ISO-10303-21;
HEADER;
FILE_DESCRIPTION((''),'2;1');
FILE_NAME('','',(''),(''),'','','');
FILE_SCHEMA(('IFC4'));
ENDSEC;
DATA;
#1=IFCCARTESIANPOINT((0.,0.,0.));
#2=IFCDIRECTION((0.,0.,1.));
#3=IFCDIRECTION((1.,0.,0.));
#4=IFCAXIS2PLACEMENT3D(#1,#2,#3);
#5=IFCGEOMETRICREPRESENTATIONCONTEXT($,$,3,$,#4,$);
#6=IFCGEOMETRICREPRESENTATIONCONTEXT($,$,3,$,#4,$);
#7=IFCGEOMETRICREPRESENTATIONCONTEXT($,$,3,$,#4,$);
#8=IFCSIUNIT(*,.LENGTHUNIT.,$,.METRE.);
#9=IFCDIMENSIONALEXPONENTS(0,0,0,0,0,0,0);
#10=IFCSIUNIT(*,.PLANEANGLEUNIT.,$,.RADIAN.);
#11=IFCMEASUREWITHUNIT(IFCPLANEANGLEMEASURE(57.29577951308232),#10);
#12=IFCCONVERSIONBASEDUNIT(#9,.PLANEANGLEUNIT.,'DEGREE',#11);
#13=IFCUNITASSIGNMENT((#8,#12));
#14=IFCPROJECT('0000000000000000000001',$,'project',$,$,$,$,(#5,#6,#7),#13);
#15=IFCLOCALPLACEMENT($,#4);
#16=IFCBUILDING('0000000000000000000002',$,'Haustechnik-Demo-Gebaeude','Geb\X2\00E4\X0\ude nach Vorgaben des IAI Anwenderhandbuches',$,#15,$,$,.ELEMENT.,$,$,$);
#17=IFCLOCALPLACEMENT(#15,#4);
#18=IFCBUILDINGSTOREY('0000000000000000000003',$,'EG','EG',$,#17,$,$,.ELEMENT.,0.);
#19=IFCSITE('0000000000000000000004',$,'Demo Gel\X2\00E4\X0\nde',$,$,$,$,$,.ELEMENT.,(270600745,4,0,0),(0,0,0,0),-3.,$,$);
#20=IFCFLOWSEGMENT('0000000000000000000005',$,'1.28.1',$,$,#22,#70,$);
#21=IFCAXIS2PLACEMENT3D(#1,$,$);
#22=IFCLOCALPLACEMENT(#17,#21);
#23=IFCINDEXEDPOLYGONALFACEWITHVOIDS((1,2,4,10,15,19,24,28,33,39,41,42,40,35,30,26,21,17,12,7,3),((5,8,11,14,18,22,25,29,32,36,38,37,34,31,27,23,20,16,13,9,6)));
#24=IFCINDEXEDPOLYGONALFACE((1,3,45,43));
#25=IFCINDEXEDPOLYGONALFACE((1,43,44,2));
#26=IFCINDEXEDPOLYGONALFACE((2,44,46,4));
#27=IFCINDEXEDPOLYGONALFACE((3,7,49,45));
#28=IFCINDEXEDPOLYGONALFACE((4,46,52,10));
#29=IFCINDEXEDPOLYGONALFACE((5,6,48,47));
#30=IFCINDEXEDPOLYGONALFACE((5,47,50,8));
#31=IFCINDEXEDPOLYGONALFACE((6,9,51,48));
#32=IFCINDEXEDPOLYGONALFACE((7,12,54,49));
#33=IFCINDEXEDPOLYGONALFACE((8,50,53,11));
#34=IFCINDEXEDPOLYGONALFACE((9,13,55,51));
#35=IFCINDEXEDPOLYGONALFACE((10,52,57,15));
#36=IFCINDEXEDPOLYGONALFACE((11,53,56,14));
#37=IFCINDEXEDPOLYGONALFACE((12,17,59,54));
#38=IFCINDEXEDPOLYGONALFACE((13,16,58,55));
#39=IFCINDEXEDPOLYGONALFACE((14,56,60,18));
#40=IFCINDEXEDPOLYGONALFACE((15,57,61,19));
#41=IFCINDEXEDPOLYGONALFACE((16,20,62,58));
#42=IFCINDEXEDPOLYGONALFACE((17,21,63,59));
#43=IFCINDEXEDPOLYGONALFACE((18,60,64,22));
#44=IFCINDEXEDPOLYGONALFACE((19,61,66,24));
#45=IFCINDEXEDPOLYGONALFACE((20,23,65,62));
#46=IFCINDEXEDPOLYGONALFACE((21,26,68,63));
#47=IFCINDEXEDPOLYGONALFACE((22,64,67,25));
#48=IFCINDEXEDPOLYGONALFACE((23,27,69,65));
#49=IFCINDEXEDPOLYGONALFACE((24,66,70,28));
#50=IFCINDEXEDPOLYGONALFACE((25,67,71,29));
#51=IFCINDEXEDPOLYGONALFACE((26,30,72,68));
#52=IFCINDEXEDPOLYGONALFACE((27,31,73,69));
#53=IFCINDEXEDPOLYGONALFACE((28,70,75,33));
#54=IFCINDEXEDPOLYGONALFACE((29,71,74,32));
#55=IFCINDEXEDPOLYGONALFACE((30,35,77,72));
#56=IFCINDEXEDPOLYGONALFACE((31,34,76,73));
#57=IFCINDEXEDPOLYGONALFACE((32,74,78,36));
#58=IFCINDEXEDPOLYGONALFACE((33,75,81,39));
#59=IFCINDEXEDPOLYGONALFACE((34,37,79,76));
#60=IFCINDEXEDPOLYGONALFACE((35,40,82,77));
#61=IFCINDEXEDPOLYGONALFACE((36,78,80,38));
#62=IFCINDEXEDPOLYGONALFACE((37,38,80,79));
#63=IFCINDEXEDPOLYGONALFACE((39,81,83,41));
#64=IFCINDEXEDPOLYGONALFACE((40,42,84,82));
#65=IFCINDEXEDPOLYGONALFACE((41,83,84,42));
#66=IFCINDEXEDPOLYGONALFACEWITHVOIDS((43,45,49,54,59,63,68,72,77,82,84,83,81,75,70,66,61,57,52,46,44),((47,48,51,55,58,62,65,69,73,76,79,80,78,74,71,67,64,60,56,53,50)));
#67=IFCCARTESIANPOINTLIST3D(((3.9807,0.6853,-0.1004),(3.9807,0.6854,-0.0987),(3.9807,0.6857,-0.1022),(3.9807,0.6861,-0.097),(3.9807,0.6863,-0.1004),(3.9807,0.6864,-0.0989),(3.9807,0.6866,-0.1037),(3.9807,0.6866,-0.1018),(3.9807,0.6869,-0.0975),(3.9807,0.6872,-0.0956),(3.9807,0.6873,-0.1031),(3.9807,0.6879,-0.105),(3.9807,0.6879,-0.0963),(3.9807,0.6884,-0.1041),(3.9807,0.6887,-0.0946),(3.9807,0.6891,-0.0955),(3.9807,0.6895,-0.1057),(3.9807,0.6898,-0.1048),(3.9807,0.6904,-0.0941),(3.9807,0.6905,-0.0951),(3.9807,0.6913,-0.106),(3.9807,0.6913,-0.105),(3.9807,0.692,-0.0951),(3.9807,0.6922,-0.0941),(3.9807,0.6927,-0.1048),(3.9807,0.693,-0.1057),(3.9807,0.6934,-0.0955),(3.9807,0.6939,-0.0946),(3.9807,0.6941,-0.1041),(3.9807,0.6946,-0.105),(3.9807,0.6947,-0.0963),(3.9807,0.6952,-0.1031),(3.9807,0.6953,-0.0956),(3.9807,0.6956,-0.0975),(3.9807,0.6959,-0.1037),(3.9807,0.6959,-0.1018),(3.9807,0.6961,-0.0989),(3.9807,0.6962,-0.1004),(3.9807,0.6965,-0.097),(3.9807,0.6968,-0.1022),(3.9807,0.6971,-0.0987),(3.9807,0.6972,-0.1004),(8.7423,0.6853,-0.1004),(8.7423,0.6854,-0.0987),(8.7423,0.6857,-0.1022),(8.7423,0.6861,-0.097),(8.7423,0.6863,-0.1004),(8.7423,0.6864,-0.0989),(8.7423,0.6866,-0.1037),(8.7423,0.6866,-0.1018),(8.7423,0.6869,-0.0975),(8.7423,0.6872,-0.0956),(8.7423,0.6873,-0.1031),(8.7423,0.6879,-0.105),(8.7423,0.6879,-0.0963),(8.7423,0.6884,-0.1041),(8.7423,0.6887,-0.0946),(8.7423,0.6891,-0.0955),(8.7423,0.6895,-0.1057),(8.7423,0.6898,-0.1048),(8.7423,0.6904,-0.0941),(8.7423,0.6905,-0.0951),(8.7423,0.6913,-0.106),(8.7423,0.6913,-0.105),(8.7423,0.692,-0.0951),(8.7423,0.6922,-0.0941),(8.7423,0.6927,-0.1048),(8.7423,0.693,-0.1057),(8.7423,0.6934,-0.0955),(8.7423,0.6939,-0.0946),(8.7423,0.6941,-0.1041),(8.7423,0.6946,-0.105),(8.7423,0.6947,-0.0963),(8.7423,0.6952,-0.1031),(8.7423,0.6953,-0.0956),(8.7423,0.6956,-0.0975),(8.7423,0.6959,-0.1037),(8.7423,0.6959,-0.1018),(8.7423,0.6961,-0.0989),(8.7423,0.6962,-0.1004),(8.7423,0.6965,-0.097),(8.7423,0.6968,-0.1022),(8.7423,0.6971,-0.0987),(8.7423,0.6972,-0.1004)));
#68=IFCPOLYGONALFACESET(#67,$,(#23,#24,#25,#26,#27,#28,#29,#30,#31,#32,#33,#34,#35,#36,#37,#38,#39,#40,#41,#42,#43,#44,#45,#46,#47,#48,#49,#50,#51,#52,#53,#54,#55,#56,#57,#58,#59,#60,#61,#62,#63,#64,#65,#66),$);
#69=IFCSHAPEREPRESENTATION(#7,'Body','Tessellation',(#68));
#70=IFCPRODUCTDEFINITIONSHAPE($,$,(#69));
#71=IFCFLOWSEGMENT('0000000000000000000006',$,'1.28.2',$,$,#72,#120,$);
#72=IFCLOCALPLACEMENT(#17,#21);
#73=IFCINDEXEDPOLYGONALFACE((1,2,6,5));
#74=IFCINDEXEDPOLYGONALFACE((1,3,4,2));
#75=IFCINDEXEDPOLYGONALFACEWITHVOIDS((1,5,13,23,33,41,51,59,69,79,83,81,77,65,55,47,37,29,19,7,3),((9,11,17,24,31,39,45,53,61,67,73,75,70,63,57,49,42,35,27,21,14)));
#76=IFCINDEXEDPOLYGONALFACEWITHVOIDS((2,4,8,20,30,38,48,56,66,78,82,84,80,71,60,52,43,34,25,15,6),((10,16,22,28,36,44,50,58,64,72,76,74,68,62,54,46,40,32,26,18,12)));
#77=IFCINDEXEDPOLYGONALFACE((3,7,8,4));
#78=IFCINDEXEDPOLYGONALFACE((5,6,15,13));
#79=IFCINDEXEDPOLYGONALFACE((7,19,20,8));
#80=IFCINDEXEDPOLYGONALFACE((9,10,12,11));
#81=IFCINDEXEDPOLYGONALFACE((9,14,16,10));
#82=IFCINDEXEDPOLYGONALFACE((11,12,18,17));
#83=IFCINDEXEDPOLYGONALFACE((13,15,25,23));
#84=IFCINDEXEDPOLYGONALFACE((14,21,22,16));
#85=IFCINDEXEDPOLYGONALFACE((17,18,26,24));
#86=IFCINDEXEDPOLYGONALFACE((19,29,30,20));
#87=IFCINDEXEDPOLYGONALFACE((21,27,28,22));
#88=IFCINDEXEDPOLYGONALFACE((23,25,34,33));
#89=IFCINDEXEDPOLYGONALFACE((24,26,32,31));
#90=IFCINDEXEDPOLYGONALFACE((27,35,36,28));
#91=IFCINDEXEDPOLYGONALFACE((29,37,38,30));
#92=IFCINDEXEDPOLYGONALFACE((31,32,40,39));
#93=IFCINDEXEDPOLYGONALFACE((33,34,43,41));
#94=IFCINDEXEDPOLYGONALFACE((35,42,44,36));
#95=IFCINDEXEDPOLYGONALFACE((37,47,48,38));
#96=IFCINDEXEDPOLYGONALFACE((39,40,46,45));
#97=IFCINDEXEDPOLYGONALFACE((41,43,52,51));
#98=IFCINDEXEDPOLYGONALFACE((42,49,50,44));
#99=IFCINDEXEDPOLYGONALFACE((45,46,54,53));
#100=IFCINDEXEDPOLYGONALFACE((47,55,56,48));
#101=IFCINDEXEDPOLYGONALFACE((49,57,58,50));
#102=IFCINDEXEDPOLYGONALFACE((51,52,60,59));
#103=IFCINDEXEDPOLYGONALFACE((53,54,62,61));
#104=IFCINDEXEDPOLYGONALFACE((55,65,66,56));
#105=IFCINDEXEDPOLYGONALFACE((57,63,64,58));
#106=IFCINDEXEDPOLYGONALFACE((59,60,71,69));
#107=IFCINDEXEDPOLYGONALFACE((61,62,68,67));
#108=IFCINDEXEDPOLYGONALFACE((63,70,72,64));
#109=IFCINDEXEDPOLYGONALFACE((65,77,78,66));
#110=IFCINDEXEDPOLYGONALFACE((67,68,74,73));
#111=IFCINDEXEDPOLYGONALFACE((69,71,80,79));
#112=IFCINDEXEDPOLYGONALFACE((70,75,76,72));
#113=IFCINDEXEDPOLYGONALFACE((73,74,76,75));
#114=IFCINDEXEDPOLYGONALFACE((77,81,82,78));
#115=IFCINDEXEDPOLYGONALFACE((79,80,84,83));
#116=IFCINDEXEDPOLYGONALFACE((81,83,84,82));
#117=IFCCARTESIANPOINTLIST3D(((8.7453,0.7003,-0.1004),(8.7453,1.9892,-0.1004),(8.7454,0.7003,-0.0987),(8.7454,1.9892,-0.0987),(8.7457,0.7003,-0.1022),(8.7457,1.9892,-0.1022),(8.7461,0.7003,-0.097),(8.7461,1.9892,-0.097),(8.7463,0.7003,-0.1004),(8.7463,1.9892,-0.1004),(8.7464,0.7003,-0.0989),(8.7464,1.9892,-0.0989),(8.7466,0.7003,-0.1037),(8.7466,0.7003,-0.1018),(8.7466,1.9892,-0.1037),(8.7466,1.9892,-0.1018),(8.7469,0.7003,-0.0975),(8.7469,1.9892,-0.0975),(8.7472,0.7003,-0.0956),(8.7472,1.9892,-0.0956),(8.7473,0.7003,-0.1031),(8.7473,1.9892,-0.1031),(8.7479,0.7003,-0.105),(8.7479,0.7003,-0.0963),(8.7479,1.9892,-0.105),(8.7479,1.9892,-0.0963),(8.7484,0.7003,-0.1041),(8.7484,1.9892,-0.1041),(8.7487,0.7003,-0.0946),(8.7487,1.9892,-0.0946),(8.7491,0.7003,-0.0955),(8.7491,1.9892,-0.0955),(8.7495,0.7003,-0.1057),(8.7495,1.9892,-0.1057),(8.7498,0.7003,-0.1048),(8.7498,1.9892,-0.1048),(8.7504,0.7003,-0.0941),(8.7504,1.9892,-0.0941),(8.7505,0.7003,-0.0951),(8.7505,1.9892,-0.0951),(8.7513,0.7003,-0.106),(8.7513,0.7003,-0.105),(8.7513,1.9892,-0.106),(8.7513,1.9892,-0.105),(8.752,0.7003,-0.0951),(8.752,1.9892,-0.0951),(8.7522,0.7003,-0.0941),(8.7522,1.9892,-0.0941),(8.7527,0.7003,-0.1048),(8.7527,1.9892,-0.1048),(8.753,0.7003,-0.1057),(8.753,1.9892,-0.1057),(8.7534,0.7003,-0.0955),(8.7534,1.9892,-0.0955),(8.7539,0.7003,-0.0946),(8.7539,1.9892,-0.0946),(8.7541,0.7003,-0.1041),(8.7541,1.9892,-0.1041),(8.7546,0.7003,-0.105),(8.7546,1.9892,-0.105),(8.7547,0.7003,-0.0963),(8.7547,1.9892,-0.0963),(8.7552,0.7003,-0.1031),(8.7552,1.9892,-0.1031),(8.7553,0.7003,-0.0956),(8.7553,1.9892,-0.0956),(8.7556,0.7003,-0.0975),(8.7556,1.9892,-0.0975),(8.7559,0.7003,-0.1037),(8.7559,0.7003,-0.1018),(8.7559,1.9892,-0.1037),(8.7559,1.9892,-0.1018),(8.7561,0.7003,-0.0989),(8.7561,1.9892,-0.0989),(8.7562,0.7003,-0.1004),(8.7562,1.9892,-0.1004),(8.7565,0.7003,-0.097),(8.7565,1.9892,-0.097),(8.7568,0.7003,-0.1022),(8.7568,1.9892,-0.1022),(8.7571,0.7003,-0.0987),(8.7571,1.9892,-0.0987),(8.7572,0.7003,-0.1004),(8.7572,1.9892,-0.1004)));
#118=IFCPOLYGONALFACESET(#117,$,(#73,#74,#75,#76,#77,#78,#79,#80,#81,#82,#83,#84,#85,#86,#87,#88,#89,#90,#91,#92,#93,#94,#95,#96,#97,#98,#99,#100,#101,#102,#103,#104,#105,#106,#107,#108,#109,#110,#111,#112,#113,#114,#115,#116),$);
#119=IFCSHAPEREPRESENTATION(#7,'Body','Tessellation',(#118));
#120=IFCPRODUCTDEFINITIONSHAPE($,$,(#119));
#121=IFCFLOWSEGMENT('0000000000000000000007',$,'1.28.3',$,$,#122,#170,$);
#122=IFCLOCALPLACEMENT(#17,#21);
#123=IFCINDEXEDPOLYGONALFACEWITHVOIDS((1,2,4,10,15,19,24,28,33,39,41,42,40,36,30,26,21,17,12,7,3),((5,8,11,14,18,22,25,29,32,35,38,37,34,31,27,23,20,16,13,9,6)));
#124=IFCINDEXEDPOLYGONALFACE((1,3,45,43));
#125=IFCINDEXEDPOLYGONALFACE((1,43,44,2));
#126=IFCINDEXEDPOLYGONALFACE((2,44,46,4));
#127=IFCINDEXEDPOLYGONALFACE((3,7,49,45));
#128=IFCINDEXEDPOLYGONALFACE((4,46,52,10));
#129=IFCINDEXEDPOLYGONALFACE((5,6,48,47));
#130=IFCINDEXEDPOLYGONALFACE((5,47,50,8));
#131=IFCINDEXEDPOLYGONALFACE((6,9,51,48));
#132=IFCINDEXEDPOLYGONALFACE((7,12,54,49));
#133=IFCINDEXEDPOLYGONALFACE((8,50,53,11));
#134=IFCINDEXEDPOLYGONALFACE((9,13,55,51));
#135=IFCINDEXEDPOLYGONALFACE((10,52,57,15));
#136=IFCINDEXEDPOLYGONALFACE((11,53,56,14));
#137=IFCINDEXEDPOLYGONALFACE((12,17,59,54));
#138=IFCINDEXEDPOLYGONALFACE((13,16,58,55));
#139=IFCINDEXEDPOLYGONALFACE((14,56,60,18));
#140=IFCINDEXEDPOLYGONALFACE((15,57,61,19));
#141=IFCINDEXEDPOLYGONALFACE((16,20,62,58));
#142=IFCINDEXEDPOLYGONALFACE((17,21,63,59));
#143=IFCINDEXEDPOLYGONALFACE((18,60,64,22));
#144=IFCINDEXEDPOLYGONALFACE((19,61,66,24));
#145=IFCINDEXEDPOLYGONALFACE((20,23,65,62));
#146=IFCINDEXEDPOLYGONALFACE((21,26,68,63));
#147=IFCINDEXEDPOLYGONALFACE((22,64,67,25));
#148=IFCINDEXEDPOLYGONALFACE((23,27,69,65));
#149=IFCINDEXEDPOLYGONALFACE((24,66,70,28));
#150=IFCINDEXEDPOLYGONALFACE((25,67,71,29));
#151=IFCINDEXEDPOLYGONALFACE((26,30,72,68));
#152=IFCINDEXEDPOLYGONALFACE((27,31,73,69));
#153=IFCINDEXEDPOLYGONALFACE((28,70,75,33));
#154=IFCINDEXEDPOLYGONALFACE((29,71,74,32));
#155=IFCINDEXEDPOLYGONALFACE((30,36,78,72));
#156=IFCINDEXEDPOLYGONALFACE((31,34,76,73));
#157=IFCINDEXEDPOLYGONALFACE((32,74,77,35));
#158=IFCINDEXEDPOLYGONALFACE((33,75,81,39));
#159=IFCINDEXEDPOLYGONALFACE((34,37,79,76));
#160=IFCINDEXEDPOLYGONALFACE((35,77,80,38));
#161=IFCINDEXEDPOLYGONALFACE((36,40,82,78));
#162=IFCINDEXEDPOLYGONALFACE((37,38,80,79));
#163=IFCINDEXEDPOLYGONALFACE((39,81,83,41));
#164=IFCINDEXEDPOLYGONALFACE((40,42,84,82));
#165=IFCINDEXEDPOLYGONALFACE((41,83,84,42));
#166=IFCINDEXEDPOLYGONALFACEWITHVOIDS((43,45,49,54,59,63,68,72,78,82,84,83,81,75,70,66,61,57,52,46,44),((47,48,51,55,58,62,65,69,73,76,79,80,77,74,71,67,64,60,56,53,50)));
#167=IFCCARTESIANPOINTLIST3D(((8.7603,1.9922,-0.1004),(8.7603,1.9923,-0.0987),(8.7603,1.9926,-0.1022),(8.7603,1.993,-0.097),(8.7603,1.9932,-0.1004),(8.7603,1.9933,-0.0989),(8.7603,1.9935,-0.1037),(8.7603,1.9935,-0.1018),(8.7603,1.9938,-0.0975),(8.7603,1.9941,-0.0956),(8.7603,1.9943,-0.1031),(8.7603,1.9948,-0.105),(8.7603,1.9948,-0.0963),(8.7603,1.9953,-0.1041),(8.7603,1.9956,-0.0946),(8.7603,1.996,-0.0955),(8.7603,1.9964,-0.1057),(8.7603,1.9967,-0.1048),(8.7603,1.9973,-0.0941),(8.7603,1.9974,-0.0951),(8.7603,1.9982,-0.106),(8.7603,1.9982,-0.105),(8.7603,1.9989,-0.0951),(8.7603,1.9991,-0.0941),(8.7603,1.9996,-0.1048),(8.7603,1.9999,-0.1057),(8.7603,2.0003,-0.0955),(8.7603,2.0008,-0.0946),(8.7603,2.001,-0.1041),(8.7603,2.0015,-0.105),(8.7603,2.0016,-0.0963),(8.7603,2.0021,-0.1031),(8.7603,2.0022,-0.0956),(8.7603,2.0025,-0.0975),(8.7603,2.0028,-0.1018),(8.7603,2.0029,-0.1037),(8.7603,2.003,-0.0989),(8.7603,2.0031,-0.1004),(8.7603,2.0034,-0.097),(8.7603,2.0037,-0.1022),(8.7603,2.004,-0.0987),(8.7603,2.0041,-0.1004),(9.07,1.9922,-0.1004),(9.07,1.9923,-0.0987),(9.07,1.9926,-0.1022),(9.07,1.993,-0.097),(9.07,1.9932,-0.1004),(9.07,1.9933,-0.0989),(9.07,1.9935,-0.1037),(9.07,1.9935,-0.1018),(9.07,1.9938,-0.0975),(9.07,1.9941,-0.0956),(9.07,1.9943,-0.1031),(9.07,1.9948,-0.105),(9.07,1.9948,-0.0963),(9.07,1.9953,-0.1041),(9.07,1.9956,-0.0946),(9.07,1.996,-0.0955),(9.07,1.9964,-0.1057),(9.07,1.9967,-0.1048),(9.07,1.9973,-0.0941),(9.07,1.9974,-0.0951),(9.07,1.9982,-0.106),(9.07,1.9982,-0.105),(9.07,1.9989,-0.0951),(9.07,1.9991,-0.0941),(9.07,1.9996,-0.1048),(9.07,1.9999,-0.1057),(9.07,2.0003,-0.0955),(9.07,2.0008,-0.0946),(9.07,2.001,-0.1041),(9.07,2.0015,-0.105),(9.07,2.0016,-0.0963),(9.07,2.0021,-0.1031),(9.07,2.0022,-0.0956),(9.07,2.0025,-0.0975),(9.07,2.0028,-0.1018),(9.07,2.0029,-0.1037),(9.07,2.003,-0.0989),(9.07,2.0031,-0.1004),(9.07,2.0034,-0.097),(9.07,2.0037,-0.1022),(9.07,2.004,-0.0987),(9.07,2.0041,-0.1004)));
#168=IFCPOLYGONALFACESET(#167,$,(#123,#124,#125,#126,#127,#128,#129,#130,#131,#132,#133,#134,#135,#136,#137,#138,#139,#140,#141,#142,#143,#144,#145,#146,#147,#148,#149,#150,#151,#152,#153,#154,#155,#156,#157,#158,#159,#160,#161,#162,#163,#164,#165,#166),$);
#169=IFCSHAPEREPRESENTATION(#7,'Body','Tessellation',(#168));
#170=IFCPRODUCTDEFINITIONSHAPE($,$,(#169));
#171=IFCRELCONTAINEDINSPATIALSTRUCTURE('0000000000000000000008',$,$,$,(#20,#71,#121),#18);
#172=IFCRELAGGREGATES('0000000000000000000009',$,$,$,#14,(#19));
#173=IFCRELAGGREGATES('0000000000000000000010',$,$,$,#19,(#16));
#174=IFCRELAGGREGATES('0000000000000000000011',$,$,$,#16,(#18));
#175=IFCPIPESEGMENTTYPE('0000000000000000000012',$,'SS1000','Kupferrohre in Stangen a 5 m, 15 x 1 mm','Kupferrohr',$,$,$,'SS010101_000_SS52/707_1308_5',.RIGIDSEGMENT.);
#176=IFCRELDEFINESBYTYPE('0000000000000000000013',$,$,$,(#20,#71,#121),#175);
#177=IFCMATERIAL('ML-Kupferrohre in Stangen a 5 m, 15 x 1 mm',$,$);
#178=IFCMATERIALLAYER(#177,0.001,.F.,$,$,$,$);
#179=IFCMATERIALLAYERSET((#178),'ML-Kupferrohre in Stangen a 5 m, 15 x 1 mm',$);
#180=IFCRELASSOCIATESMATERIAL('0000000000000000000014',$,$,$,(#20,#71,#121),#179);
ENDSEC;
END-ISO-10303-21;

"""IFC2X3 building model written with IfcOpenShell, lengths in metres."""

from ifc_helpers import new_model, entity, si_unit, converted_unit, frame, origin_with_axes, origin_2d_with_axis, place, context, project, spatial, hollow_circle, extrude, material, layer, layer_set, layer_usage, type_object, element, save


model = new_model("IFC2X3")

# Units and contexts
context_of_model_1 = context(None, 3, world=origin_with_axes())
context_of_model_2 = context(None, 3, world=origin_with_axes())
context_of_model_3 = context(None, 3, world=origin_with_axes())
ifc_project = project(units=[si_unit("LENGTHUNIT", "METRE"), converted_unit("PLANEANGLEUNIT", "DEGREE", entity("IfcPlaneAngleMeasure", 57.29577951308232), si_unit("PLANEANGLEUNIT", "RADIAN"), dimensions=[0, 0, 0, 0, 0, 0, 0])], contexts=[context_of_model_1, context_of_model_2, context_of_model_3])

# Site, building, storey
site = spatial("IfcSite", under=ifc_project, Name="Demo Gelände", CompositionType="ELEMENT", RefLatitude=(270600745, 4, 0, 0), RefLongitude=(0, 0, 0, 0), RefElevation=-3.0)
building_placement = place(None, origin_with_axes())
building = spatial("IfcBuilding", under=site, at=building_placement, Name="Haustechnik-Demo-Gebaeude", Description="Gebäude nach Vorgaben des IAI Anwenderhandbuches", CompositionType="ELEMENT")
storey_placement = place(building_placement, origin_with_axes())
storey = spatial("IfcBuildingStorey", under=building, at=storey_placement, Name="EG", Description="EG", CompositionType="ELEMENT", Elevation=0.0)

# Flow segments
ifc_material = material(Name="ML-Kupferrohre in Stangen a 5 m, 15 x 1 mm")
ifc_layer = layer(ifc_material, 0.001, ventilated=False)
ifc_layer_set = layer_set([ifc_layer], Name="ML-Kupferrohre in Stangen a 5 m, 15 x 1 mm")
ifc_layer_usage = layer_usage(ifc_layer_set, "AXIS2", "POSITIVE", 0.0)
pipe_segment_type_1 = type_object("IfcPipeSegmentType", Name="SS1000", Description="Kupferrohre in Stangen a 5 m, 15 x 1 mm", ApplicableOccurrence="Kupferrohr", ElementType="SS010101_000_SS52/707_1308_5", PredefinedType="RIGIDSEGMENT")
flow_segment_1_placement = place(storey_placement, frame((3.9807, 0.6913, -0.1), z_axis=(1.0, 0.0, 0.0), x_axis=(0.0, 0.0, -1.0)))
element("IfcFlowSegment", 1, at=flow_segment_1_placement, inside=storey, type_object=pipe_segment_type_1, material=ifc_layer_usage, Name="1.28.1", context=context_of_model_3, shape_type="SweptSolid", body=[
    extrude(hollow_circle(Radius=0.006, WallThickness=0.001, at=origin_2d_with_axis()), origin_with_axes(), (0.0, 0.0, 1.0), 4.7616),
])
flow_segment_2_placement = place(storey_placement, frame((8.7513, 0.7003, -0.1), z_axis=(0.0, 1.0, 0.0), x_axis=(0.0, 0.0, -1.0)))
element("IfcFlowSegment", 2, at=flow_segment_2_placement, inside=storey, type_object=pipe_segment_type_1, material=ifc_layer_usage, Name="1.28.2", context=context_of_model_3, shape_type="SweptSolid", body=[
    extrude(hollow_circle(Radius=0.006, WallThickness=0.001, at=origin_2d_with_axis()), origin_with_axes(), (0.0, 0.0, 1.0), 1.2889),
])
flow_segment_3_placement = place(storey_placement, frame((8.7603, 1.9982, -0.1), z_axis=(1.0, 0.0, 0.0), x_axis=(0.0, 0.0, -1.0)))
element("IfcFlowSegment", 3, at=flow_segment_3_placement, inside=storey, type_object=pipe_segment_type_1, material=ifc_layer_usage, Name="1.28.3", context=context_of_model_3, shape_type="SweptSolid", body=[
    extrude(hollow_circle(Radius=0.006, WallThickness=0.001, at=origin_2d_with_axis()), origin_with_axes(), (0.0, 0.0, 1.0), 0.3097),
])

save(model, "model.ifc")
